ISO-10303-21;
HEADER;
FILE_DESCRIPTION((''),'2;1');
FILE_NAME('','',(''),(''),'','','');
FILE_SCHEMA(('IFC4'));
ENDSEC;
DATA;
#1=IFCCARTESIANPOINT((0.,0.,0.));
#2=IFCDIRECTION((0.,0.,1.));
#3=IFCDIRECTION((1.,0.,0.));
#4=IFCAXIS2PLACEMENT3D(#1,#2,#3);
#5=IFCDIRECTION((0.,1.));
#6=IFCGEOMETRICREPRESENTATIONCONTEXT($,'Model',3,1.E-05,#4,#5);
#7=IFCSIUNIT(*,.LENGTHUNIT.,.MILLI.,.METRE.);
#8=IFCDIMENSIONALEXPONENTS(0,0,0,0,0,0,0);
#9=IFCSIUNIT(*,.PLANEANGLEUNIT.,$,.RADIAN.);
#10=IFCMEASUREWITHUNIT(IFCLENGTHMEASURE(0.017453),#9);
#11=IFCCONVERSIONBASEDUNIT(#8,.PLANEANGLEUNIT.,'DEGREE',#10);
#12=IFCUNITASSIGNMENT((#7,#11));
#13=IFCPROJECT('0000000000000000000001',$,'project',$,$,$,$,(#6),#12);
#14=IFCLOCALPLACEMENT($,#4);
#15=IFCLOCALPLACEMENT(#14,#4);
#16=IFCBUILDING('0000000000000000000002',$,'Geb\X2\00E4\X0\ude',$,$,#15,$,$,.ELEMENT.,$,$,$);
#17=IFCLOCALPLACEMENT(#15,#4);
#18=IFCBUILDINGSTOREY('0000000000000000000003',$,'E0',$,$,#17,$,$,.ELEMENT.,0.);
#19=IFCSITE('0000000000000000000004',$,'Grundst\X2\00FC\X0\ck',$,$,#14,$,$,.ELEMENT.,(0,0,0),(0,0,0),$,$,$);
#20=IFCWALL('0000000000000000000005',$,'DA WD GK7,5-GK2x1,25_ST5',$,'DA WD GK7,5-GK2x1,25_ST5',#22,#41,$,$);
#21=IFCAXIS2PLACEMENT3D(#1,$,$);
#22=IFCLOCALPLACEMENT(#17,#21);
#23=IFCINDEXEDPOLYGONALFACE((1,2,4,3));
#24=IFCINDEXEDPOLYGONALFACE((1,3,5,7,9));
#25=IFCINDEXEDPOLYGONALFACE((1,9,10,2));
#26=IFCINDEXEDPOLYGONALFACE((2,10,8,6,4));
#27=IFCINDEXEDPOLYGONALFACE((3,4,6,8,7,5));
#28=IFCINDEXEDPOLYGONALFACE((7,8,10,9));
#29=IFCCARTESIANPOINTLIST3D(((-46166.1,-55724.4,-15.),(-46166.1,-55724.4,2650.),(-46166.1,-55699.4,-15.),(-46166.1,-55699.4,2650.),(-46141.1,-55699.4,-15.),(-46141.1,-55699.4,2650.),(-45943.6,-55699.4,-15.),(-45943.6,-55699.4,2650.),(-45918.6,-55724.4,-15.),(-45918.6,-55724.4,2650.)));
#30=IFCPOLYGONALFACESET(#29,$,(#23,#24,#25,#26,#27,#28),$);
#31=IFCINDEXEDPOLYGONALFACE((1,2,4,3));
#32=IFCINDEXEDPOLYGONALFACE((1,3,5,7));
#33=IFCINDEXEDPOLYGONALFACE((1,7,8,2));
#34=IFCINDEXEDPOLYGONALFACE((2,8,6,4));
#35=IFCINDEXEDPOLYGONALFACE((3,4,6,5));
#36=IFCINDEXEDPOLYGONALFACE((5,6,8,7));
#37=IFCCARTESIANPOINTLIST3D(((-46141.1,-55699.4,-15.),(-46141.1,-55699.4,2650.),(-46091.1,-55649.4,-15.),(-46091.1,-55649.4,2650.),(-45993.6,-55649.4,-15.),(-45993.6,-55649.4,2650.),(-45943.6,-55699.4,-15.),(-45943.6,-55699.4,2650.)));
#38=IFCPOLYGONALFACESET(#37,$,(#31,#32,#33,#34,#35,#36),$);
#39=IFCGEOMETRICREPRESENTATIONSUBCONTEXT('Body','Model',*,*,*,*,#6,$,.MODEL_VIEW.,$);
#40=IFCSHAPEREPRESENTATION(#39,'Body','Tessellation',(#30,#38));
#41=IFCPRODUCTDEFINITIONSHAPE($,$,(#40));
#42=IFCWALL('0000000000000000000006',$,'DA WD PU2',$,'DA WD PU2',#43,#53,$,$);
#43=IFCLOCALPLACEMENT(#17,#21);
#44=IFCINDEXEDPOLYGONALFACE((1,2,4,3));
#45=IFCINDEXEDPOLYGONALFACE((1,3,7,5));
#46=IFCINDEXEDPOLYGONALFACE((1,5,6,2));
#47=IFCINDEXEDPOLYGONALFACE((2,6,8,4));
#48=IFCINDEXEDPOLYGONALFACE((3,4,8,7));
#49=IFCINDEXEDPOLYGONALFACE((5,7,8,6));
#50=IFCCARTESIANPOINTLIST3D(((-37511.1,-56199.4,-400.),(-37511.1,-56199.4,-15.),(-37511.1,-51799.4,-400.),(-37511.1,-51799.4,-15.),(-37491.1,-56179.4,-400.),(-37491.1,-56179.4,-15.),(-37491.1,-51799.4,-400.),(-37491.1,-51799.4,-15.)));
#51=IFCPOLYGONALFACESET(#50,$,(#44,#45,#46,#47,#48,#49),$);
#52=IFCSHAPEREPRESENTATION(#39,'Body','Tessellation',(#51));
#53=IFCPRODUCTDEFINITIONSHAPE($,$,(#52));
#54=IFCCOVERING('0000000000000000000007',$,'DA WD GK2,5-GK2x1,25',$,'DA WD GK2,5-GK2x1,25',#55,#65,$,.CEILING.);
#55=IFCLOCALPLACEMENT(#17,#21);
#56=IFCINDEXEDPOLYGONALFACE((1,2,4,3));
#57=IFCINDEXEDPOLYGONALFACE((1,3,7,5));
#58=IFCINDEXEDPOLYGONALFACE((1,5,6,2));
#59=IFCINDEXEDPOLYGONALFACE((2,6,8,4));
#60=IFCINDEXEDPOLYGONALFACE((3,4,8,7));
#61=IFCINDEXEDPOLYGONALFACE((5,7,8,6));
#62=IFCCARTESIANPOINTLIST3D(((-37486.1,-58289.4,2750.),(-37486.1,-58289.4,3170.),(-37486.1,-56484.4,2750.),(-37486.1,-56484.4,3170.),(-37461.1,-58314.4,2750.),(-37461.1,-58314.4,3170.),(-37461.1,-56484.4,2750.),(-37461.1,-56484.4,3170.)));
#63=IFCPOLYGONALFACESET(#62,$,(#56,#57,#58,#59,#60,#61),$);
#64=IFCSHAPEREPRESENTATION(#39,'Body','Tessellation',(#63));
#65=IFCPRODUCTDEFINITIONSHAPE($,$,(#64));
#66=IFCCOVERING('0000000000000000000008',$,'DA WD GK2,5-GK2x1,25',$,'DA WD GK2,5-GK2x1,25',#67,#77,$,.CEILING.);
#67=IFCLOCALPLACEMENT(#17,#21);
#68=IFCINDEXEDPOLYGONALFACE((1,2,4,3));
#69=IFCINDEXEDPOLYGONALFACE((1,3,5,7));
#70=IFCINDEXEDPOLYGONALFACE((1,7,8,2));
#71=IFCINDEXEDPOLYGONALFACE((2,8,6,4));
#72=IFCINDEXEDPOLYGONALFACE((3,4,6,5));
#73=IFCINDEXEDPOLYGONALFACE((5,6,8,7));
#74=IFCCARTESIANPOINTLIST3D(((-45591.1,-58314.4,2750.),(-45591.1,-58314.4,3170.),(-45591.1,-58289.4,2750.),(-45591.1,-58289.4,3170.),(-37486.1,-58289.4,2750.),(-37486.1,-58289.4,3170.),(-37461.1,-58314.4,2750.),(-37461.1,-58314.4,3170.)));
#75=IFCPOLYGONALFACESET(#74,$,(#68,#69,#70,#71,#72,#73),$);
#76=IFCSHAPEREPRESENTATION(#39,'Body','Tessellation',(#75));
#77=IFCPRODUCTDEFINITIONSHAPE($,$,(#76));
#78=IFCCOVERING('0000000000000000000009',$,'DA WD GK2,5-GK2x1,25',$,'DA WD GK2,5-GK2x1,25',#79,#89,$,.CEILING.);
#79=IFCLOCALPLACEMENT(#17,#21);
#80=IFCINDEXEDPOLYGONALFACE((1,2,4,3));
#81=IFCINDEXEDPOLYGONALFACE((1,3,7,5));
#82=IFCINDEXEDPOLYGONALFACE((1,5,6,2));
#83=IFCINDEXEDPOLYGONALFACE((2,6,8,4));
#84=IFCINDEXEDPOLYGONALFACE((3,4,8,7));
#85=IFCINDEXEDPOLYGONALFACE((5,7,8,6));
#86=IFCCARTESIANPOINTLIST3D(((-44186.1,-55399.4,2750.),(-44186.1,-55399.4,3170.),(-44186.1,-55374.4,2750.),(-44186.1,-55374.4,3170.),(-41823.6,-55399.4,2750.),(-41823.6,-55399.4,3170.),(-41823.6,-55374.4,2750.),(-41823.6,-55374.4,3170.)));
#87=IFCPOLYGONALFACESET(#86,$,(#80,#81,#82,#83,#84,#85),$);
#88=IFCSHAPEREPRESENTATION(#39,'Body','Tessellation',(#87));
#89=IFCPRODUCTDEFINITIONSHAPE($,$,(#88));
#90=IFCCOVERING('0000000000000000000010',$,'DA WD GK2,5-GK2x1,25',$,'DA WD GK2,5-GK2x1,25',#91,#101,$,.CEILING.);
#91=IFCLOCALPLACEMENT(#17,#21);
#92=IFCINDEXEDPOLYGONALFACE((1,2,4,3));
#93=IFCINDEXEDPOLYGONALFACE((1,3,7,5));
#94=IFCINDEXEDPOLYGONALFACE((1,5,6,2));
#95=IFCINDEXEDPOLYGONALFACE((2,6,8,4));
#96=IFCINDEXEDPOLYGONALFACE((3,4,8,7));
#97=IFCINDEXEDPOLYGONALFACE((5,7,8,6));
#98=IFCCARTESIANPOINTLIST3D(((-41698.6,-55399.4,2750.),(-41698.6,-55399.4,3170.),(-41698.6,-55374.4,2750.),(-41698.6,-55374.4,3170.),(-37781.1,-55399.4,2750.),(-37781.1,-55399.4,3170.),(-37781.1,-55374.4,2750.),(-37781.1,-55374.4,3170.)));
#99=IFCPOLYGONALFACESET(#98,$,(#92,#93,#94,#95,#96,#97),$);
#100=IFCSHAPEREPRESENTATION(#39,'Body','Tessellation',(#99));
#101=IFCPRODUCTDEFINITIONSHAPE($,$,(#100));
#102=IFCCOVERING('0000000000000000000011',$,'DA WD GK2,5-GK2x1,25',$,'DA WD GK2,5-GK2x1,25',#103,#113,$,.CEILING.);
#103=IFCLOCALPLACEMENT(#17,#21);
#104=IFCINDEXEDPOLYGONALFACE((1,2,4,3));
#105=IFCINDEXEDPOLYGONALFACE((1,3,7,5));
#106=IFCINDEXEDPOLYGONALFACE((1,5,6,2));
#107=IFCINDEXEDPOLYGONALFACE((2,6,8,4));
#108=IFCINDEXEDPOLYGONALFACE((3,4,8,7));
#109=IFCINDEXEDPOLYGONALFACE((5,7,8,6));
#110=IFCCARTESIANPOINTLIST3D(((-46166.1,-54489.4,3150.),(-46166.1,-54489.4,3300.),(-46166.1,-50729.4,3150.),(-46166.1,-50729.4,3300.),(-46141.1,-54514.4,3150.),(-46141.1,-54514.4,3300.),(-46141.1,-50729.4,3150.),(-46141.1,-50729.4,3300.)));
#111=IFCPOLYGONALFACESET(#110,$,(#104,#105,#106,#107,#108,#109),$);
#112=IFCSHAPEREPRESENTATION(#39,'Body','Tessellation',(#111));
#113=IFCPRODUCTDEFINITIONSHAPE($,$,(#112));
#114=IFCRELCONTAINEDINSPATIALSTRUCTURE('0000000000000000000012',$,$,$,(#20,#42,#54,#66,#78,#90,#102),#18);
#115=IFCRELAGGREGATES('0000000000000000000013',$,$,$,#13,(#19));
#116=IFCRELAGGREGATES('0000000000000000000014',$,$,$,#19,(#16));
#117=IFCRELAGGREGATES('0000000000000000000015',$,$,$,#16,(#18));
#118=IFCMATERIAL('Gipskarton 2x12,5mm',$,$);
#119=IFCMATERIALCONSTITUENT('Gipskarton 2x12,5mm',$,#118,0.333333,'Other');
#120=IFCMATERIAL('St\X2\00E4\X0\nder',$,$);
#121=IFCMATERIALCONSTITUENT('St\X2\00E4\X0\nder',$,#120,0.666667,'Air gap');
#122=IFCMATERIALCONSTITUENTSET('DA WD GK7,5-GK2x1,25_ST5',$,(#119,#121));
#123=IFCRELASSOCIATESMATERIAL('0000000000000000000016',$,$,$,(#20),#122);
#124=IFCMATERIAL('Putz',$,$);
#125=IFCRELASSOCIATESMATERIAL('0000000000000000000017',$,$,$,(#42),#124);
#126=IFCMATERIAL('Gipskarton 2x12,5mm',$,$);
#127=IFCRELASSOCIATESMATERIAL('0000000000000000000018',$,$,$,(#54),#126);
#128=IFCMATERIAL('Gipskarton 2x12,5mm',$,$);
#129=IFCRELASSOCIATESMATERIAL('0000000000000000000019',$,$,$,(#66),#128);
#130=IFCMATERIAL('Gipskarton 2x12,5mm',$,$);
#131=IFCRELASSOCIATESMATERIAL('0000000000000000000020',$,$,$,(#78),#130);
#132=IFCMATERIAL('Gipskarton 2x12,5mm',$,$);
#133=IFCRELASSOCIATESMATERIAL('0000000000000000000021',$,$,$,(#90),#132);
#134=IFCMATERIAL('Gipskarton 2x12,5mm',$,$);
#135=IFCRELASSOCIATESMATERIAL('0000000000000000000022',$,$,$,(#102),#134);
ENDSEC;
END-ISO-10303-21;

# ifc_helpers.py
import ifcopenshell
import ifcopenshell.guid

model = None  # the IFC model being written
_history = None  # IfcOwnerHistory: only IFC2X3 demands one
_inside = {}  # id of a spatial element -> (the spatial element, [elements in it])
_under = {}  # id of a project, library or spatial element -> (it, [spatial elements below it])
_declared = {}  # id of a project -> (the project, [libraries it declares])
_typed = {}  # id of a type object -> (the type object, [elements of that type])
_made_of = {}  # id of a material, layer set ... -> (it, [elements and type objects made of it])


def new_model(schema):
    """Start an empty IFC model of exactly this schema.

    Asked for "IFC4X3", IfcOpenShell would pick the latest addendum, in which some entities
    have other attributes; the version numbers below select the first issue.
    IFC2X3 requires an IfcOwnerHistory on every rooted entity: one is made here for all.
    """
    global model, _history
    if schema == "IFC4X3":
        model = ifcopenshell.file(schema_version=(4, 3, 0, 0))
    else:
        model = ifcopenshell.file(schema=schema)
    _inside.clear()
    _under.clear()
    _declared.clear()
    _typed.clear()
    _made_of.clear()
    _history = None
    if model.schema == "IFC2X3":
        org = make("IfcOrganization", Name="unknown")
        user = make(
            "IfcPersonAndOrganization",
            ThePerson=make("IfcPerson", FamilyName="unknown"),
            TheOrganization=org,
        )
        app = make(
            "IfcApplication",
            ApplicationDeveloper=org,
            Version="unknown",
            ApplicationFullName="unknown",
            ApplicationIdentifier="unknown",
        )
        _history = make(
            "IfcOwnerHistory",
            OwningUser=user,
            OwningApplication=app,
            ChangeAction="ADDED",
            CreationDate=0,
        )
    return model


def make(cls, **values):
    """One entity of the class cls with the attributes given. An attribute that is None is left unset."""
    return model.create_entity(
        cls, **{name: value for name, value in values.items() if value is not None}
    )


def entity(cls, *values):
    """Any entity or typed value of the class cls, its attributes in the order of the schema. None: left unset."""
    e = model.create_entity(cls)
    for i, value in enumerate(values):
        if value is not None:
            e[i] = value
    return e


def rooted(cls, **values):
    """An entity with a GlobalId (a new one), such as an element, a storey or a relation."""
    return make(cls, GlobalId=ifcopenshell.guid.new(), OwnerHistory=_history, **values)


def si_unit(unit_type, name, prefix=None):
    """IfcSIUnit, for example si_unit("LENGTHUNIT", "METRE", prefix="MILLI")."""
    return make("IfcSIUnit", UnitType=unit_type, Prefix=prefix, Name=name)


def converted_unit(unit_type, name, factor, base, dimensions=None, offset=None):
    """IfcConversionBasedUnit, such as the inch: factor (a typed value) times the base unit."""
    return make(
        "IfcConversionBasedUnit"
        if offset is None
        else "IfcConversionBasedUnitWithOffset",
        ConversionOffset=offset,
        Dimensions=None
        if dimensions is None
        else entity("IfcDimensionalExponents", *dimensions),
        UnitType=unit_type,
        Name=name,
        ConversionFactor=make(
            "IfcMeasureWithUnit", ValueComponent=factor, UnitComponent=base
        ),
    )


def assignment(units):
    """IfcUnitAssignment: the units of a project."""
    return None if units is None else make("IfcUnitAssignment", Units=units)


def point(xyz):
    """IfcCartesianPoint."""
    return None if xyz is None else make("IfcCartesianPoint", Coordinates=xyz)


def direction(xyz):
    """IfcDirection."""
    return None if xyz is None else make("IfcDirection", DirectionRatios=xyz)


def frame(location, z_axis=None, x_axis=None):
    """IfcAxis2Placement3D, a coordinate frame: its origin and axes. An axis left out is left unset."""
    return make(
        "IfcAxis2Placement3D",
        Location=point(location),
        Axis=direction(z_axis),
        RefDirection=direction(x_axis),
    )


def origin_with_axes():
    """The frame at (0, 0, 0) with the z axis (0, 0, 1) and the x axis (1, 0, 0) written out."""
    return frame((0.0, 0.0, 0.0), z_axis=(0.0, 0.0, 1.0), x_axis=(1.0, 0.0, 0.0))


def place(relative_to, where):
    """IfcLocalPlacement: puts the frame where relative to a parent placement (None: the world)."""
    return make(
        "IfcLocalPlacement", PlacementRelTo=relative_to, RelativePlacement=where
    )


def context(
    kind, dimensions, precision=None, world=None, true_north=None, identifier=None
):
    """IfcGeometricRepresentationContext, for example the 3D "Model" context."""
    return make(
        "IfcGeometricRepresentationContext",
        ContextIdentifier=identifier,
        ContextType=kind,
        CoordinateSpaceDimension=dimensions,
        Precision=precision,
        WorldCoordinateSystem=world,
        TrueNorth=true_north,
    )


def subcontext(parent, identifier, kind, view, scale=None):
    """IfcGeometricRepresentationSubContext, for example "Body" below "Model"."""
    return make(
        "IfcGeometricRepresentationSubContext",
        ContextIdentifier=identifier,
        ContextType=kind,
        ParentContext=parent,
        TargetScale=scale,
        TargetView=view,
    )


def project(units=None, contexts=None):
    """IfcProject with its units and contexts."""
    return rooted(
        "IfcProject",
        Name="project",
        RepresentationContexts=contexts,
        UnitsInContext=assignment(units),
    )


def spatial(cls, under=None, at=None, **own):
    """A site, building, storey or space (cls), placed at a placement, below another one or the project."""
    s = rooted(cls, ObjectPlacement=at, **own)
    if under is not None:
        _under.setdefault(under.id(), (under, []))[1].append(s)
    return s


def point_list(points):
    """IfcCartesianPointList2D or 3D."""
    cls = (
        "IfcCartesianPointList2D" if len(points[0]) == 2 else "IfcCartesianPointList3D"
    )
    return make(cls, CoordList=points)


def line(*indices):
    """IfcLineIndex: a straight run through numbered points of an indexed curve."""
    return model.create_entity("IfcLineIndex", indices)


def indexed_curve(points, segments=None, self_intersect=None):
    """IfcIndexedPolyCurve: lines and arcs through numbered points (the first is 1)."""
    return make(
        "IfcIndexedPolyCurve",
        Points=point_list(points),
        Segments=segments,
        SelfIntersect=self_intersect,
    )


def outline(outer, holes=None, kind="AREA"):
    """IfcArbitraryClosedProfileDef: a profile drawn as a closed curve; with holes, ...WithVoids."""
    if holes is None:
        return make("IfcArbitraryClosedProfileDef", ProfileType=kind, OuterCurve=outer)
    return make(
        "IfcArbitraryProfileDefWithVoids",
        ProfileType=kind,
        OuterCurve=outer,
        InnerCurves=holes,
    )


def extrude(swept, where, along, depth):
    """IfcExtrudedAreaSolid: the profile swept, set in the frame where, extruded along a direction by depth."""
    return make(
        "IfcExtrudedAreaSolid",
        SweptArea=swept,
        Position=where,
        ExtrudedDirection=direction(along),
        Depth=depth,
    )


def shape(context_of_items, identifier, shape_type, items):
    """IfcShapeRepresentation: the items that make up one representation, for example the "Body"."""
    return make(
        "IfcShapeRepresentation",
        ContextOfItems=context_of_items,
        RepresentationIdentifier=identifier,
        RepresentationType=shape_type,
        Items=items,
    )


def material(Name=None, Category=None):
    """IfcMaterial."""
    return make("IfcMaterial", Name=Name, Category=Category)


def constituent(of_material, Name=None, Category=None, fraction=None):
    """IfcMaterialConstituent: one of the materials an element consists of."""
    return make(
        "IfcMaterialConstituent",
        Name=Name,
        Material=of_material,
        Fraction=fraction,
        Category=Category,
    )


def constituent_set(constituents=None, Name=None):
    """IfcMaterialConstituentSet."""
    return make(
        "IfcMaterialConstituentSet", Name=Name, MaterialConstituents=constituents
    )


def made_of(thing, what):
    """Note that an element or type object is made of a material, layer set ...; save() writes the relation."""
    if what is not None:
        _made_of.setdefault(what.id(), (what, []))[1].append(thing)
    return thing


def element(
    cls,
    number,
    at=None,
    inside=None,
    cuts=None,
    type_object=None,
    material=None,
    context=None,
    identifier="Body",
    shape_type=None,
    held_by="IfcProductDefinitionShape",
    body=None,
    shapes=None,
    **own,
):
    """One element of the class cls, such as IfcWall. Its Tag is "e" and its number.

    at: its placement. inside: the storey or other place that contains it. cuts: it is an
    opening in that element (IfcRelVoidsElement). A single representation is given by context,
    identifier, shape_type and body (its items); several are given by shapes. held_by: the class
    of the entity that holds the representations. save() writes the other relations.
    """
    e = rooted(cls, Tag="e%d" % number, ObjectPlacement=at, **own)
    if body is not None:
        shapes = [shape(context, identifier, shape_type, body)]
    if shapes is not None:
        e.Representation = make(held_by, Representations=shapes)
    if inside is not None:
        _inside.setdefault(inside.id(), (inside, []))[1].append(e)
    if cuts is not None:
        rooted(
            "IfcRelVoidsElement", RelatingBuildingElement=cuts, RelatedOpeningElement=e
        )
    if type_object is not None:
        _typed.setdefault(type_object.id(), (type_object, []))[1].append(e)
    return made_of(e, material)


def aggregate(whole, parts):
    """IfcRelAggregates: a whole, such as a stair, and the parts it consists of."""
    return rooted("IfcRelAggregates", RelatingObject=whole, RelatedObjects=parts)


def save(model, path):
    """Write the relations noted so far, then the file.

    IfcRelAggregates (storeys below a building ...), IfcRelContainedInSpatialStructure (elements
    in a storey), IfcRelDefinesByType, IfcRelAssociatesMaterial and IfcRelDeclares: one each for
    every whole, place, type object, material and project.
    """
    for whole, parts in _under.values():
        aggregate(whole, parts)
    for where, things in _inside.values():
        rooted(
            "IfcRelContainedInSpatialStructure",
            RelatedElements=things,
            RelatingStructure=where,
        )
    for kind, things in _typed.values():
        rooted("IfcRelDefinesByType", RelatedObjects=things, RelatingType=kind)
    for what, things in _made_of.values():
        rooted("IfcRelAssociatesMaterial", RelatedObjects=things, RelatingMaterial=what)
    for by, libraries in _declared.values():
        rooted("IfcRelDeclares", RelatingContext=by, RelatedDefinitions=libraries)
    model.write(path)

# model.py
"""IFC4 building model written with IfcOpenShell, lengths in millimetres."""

from ifc_helpers import new_model, entity, si_unit, converted_unit, direction, frame, origin_with_axes, place, context, subcontext, project, spatial, line, indexed_curve, outline, extrude, material, constituent, constituent_set, element, save


model = new_model("IFC4")

# Units and contexts
model_context = context("Model", 3, precision=1e-05, world=origin_with_axes(), true_north=direction((0.0, 1.0)))
body_context = subcontext(model_context, "Body", "Model", "MODEL_VIEW")
ifc_project = project(units=[si_unit("LENGTHUNIT", "METRE", prefix="MILLI"), converted_unit("PLANEANGLEUNIT", "DEGREE", entity("IfcLengthMeasure", 0.017453), si_unit("PLANEANGLEUNIT", "RADIAN"), dimensions=[0, 0, 0, 0, 0, 0, 0])], contexts=[model_context])

# Site, building, storey
site_placement = place(None, origin_with_axes())
site = spatial("IfcSite", under=ifc_project, at=site_placement, Name="Grundstück", CompositionType="ELEMENT", RefLatitude=(0, 0, 0), RefLongitude=(0, 0, 0))
building_placement = place(site_placement, origin_with_axes())
building = spatial("IfcBuilding", under=site, at=building_placement, Name="Gebäude", CompositionType="ELEMENT")
storey_placement = place(building_placement, origin_with_axes())
storey = spatial("IfcBuildingStorey", under=building, at=storey_placement, Name="E0", CompositionType="ELEMENT", Elevation=0.0)

# Walls
ifc_material_1 = material(Name="Gipskarton 2x12,5mm")
ifc_constituent_1 = constituent(ifc_material_1, Name="Gipskarton 2x12,5mm", Category="Other", fraction=0.333333)
ifc_material_2 = material(Name="Ständer")
ifc_constituent_2 = constituent(ifc_material_2, Name="Ständer", Category="Air gap", fraction=0.666667)
ifc_constituent_set_1 = constituent_set(constituents=[ifc_constituent_1, ifc_constituent_2], Name="DA WD GK7,5-GK2x1,25_ST5")
wall_1_placement = place(storey_placement, frame((-45956.1, -55686.9, -15.0), z_axis=(0.0, 0.0, 1.0), x_axis=(-1.0, 0.0, 0.0)))
element("IfcWall", 1, at=wall_1_placement, inside=storey, material=ifc_constituent_set_1, Name="DA WD GK7,5-GK2x1,25_ST5", ObjectType="DA WD GK7,5-GK2x1,25_ST5", context=body_context, shape_type="SweptSolid", body=[
    extrude(outline(indexed_curve([(-37.5, 37.5), (210.0, 37.5), (210.0, 12.5), (185.0, 12.5), (-12.5, 12.5)], segments=[line(1, 2), line(2, 3), line(3, 4), line(4, 5), line(5, 1)])), origin_with_axes(), (0.0, 0.0, 1.0), 2665.0),
    extrude(outline(indexed_curve([(185.0, 12.5), (135.0, -37.5), (37.5, -37.5), (-12.5, 12.5)], segments=[line(1, 2), line(2, 3), line(3, 4), line(4, 1)])), origin_with_axes(), (0.0, 0.0, 1.0), 2665.0),
])
ifc_material_3 = material(Name="Putz")
wall_2_placement = place(storey_placement, frame((-37501.1, -56189.4, -400.0), z_axis=(0.0, 0.0, 1.0), x_axis=(0.0, 1.0, 0.0)))
element("IfcWall", 2, at=wall_2_placement, inside=storey, material=ifc_material_3, Name="DA WD PU2", ObjectType="DA WD PU2", context=body_context, shape_type="SweptSolid", body=[
    extrude(outline(indexed_curve([(10.0, -10.0), (-10.0, 10.0), (4390.0, 10.0), (4390.0, -10.0)], segments=[line(1, 2), line(2, 3), line(3, 4), line(4, 1)])), origin_with_axes(), (0.0, 0.0, 1.0), 385.0),
])

# Coverings
ifc_material_4 = material(Name="Gipskarton 2x12,5mm")
covering_1_placement = place(storey_placement, frame((-37473.6, -58301.9, 2750.0), z_axis=(0.0, 0.0, 1.0), x_axis=(0.0, 1.0, 0.0)))
element("IfcCovering", 3, at=covering_1_placement, inside=storey, material=ifc_material_4, Name="DA WD GK2,5-GK2x1,25", ObjectType="DA WD GK2,5-GK2x1,25", PredefinedType="CEILING", context=body_context, shape_type="SweptSolid", body=[
    extrude(outline(indexed_curve([(-12.5, -12.5), (12.5, 12.5), (1817.5, 12.5), (1817.5, -12.5)], segments=[line(1, 2), line(2, 3), line(3, 4), line(4, 1)])), origin_with_axes(), (0.0, 0.0, 1.0), 420.0),
])
ifc_material_5 = material(Name="Gipskarton 2x12,5mm")
covering_2_placement = place(storey_placement, frame((-45591.1, -58301.9, 2750.0), z_axis=(0.0, 0.0, 1.0), x_axis=(1.0, 0.0, 0.0)))
element("IfcCovering", 4, at=covering_2_placement, inside=storey, material=ifc_material_5, Name="DA WD GK2,5-GK2x1,25", ObjectType="DA WD GK2,5-GK2x1,25", PredefinedType="CEILING", context=body_context, shape_type="SweptSolid", body=[
    extrude(outline(indexed_curve([(0.0, -12.5), (0.0, 12.5), (8105.0, 12.5), (8130.0, -12.5)], segments=[line(1, 2), line(2, 3), line(3, 4), line(4, 1)])), origin_with_axes(), (0.0, 0.0, 1.0), 420.0),
])
ifc_material_6 = material(Name="Gipskarton 2x12,5mm")
covering_3_placement = place(storey_placement, frame((-44186.1, -55386.9, 2750.0), z_axis=(0.0, 0.0, 1.0), x_axis=(1.0, 0.0, 0.0)))
element("IfcCovering", 5, at=covering_3_placement, inside=storey, material=ifc_material_6, Name="DA WD GK2,5-GK2x1,25", ObjectType="DA WD GK2,5-GK2x1,25", PredefinedType="CEILING", context=body_context, shape_type="SweptSolid", body=[
    extrude(outline(indexed_curve([(0.0, -12.5), (0.0, 12.5), (2362.5, 12.5), (2362.5, -12.5)], segments=[line(1, 2), line(2, 3), line(3, 4), line(4, 1)])), origin_with_axes(), (0.0, 0.0, 1.0), 420.0),
])
ifc_material_7 = material(Name="Gipskarton 2x12,5mm")
covering_4_placement = place(storey_placement, frame((-41698.6, -55386.9, 2750.0), z_axis=(0.0, 0.0, 1.0), x_axis=(1.0, 0.0, 0.0)))
element("IfcCovering", 6, at=covering_4_placement, inside=storey, material=ifc_material_7, Name="DA WD GK2,5-GK2x1,25", ObjectType="DA WD GK2,5-GK2x1,25", PredefinedType="CEILING", context=body_context, shape_type="SweptSolid", body=[
    extrude(outline(indexed_curve([(0.0, -12.5), (0.0, 12.5), (3917.5, 12.5), (3917.5, -12.5)], segments=[line(1, 2), line(2, 3), line(3, 4), line(4, 1)])), origin_with_axes(), (0.0, 0.0, 1.0), 420.0),
])
ifc_material_8 = material(Name="Gipskarton 2x12,5mm")
covering_5_placement = place(storey_placement, frame((-46153.6, -54501.9, 3150.0), z_axis=(0.0, 0.0, 1.0), x_axis=(0.0, 1.0, 0.0)))
element("IfcCovering", 7, at=covering_5_placement, inside=storey, material=ifc_material_8, Name="DA WD GK2,5-GK2x1,25", ObjectType="DA WD GK2,5-GK2x1,25", PredefinedType="CEILING", context=body_context, shape_type="SweptSolid", body=[
    extrude(outline(indexed_curve([(-12.5, -12.5), (12.5, 12.5), (3772.5, 12.5), (3772.5, -12.5)], segments=[line(1, 2), line(2, 3), line(3, 4), line(4, 1)])), origin_with_axes(), (0.0, 0.0, 1.0), 150.0),
])

save(model, "model.ifc")
